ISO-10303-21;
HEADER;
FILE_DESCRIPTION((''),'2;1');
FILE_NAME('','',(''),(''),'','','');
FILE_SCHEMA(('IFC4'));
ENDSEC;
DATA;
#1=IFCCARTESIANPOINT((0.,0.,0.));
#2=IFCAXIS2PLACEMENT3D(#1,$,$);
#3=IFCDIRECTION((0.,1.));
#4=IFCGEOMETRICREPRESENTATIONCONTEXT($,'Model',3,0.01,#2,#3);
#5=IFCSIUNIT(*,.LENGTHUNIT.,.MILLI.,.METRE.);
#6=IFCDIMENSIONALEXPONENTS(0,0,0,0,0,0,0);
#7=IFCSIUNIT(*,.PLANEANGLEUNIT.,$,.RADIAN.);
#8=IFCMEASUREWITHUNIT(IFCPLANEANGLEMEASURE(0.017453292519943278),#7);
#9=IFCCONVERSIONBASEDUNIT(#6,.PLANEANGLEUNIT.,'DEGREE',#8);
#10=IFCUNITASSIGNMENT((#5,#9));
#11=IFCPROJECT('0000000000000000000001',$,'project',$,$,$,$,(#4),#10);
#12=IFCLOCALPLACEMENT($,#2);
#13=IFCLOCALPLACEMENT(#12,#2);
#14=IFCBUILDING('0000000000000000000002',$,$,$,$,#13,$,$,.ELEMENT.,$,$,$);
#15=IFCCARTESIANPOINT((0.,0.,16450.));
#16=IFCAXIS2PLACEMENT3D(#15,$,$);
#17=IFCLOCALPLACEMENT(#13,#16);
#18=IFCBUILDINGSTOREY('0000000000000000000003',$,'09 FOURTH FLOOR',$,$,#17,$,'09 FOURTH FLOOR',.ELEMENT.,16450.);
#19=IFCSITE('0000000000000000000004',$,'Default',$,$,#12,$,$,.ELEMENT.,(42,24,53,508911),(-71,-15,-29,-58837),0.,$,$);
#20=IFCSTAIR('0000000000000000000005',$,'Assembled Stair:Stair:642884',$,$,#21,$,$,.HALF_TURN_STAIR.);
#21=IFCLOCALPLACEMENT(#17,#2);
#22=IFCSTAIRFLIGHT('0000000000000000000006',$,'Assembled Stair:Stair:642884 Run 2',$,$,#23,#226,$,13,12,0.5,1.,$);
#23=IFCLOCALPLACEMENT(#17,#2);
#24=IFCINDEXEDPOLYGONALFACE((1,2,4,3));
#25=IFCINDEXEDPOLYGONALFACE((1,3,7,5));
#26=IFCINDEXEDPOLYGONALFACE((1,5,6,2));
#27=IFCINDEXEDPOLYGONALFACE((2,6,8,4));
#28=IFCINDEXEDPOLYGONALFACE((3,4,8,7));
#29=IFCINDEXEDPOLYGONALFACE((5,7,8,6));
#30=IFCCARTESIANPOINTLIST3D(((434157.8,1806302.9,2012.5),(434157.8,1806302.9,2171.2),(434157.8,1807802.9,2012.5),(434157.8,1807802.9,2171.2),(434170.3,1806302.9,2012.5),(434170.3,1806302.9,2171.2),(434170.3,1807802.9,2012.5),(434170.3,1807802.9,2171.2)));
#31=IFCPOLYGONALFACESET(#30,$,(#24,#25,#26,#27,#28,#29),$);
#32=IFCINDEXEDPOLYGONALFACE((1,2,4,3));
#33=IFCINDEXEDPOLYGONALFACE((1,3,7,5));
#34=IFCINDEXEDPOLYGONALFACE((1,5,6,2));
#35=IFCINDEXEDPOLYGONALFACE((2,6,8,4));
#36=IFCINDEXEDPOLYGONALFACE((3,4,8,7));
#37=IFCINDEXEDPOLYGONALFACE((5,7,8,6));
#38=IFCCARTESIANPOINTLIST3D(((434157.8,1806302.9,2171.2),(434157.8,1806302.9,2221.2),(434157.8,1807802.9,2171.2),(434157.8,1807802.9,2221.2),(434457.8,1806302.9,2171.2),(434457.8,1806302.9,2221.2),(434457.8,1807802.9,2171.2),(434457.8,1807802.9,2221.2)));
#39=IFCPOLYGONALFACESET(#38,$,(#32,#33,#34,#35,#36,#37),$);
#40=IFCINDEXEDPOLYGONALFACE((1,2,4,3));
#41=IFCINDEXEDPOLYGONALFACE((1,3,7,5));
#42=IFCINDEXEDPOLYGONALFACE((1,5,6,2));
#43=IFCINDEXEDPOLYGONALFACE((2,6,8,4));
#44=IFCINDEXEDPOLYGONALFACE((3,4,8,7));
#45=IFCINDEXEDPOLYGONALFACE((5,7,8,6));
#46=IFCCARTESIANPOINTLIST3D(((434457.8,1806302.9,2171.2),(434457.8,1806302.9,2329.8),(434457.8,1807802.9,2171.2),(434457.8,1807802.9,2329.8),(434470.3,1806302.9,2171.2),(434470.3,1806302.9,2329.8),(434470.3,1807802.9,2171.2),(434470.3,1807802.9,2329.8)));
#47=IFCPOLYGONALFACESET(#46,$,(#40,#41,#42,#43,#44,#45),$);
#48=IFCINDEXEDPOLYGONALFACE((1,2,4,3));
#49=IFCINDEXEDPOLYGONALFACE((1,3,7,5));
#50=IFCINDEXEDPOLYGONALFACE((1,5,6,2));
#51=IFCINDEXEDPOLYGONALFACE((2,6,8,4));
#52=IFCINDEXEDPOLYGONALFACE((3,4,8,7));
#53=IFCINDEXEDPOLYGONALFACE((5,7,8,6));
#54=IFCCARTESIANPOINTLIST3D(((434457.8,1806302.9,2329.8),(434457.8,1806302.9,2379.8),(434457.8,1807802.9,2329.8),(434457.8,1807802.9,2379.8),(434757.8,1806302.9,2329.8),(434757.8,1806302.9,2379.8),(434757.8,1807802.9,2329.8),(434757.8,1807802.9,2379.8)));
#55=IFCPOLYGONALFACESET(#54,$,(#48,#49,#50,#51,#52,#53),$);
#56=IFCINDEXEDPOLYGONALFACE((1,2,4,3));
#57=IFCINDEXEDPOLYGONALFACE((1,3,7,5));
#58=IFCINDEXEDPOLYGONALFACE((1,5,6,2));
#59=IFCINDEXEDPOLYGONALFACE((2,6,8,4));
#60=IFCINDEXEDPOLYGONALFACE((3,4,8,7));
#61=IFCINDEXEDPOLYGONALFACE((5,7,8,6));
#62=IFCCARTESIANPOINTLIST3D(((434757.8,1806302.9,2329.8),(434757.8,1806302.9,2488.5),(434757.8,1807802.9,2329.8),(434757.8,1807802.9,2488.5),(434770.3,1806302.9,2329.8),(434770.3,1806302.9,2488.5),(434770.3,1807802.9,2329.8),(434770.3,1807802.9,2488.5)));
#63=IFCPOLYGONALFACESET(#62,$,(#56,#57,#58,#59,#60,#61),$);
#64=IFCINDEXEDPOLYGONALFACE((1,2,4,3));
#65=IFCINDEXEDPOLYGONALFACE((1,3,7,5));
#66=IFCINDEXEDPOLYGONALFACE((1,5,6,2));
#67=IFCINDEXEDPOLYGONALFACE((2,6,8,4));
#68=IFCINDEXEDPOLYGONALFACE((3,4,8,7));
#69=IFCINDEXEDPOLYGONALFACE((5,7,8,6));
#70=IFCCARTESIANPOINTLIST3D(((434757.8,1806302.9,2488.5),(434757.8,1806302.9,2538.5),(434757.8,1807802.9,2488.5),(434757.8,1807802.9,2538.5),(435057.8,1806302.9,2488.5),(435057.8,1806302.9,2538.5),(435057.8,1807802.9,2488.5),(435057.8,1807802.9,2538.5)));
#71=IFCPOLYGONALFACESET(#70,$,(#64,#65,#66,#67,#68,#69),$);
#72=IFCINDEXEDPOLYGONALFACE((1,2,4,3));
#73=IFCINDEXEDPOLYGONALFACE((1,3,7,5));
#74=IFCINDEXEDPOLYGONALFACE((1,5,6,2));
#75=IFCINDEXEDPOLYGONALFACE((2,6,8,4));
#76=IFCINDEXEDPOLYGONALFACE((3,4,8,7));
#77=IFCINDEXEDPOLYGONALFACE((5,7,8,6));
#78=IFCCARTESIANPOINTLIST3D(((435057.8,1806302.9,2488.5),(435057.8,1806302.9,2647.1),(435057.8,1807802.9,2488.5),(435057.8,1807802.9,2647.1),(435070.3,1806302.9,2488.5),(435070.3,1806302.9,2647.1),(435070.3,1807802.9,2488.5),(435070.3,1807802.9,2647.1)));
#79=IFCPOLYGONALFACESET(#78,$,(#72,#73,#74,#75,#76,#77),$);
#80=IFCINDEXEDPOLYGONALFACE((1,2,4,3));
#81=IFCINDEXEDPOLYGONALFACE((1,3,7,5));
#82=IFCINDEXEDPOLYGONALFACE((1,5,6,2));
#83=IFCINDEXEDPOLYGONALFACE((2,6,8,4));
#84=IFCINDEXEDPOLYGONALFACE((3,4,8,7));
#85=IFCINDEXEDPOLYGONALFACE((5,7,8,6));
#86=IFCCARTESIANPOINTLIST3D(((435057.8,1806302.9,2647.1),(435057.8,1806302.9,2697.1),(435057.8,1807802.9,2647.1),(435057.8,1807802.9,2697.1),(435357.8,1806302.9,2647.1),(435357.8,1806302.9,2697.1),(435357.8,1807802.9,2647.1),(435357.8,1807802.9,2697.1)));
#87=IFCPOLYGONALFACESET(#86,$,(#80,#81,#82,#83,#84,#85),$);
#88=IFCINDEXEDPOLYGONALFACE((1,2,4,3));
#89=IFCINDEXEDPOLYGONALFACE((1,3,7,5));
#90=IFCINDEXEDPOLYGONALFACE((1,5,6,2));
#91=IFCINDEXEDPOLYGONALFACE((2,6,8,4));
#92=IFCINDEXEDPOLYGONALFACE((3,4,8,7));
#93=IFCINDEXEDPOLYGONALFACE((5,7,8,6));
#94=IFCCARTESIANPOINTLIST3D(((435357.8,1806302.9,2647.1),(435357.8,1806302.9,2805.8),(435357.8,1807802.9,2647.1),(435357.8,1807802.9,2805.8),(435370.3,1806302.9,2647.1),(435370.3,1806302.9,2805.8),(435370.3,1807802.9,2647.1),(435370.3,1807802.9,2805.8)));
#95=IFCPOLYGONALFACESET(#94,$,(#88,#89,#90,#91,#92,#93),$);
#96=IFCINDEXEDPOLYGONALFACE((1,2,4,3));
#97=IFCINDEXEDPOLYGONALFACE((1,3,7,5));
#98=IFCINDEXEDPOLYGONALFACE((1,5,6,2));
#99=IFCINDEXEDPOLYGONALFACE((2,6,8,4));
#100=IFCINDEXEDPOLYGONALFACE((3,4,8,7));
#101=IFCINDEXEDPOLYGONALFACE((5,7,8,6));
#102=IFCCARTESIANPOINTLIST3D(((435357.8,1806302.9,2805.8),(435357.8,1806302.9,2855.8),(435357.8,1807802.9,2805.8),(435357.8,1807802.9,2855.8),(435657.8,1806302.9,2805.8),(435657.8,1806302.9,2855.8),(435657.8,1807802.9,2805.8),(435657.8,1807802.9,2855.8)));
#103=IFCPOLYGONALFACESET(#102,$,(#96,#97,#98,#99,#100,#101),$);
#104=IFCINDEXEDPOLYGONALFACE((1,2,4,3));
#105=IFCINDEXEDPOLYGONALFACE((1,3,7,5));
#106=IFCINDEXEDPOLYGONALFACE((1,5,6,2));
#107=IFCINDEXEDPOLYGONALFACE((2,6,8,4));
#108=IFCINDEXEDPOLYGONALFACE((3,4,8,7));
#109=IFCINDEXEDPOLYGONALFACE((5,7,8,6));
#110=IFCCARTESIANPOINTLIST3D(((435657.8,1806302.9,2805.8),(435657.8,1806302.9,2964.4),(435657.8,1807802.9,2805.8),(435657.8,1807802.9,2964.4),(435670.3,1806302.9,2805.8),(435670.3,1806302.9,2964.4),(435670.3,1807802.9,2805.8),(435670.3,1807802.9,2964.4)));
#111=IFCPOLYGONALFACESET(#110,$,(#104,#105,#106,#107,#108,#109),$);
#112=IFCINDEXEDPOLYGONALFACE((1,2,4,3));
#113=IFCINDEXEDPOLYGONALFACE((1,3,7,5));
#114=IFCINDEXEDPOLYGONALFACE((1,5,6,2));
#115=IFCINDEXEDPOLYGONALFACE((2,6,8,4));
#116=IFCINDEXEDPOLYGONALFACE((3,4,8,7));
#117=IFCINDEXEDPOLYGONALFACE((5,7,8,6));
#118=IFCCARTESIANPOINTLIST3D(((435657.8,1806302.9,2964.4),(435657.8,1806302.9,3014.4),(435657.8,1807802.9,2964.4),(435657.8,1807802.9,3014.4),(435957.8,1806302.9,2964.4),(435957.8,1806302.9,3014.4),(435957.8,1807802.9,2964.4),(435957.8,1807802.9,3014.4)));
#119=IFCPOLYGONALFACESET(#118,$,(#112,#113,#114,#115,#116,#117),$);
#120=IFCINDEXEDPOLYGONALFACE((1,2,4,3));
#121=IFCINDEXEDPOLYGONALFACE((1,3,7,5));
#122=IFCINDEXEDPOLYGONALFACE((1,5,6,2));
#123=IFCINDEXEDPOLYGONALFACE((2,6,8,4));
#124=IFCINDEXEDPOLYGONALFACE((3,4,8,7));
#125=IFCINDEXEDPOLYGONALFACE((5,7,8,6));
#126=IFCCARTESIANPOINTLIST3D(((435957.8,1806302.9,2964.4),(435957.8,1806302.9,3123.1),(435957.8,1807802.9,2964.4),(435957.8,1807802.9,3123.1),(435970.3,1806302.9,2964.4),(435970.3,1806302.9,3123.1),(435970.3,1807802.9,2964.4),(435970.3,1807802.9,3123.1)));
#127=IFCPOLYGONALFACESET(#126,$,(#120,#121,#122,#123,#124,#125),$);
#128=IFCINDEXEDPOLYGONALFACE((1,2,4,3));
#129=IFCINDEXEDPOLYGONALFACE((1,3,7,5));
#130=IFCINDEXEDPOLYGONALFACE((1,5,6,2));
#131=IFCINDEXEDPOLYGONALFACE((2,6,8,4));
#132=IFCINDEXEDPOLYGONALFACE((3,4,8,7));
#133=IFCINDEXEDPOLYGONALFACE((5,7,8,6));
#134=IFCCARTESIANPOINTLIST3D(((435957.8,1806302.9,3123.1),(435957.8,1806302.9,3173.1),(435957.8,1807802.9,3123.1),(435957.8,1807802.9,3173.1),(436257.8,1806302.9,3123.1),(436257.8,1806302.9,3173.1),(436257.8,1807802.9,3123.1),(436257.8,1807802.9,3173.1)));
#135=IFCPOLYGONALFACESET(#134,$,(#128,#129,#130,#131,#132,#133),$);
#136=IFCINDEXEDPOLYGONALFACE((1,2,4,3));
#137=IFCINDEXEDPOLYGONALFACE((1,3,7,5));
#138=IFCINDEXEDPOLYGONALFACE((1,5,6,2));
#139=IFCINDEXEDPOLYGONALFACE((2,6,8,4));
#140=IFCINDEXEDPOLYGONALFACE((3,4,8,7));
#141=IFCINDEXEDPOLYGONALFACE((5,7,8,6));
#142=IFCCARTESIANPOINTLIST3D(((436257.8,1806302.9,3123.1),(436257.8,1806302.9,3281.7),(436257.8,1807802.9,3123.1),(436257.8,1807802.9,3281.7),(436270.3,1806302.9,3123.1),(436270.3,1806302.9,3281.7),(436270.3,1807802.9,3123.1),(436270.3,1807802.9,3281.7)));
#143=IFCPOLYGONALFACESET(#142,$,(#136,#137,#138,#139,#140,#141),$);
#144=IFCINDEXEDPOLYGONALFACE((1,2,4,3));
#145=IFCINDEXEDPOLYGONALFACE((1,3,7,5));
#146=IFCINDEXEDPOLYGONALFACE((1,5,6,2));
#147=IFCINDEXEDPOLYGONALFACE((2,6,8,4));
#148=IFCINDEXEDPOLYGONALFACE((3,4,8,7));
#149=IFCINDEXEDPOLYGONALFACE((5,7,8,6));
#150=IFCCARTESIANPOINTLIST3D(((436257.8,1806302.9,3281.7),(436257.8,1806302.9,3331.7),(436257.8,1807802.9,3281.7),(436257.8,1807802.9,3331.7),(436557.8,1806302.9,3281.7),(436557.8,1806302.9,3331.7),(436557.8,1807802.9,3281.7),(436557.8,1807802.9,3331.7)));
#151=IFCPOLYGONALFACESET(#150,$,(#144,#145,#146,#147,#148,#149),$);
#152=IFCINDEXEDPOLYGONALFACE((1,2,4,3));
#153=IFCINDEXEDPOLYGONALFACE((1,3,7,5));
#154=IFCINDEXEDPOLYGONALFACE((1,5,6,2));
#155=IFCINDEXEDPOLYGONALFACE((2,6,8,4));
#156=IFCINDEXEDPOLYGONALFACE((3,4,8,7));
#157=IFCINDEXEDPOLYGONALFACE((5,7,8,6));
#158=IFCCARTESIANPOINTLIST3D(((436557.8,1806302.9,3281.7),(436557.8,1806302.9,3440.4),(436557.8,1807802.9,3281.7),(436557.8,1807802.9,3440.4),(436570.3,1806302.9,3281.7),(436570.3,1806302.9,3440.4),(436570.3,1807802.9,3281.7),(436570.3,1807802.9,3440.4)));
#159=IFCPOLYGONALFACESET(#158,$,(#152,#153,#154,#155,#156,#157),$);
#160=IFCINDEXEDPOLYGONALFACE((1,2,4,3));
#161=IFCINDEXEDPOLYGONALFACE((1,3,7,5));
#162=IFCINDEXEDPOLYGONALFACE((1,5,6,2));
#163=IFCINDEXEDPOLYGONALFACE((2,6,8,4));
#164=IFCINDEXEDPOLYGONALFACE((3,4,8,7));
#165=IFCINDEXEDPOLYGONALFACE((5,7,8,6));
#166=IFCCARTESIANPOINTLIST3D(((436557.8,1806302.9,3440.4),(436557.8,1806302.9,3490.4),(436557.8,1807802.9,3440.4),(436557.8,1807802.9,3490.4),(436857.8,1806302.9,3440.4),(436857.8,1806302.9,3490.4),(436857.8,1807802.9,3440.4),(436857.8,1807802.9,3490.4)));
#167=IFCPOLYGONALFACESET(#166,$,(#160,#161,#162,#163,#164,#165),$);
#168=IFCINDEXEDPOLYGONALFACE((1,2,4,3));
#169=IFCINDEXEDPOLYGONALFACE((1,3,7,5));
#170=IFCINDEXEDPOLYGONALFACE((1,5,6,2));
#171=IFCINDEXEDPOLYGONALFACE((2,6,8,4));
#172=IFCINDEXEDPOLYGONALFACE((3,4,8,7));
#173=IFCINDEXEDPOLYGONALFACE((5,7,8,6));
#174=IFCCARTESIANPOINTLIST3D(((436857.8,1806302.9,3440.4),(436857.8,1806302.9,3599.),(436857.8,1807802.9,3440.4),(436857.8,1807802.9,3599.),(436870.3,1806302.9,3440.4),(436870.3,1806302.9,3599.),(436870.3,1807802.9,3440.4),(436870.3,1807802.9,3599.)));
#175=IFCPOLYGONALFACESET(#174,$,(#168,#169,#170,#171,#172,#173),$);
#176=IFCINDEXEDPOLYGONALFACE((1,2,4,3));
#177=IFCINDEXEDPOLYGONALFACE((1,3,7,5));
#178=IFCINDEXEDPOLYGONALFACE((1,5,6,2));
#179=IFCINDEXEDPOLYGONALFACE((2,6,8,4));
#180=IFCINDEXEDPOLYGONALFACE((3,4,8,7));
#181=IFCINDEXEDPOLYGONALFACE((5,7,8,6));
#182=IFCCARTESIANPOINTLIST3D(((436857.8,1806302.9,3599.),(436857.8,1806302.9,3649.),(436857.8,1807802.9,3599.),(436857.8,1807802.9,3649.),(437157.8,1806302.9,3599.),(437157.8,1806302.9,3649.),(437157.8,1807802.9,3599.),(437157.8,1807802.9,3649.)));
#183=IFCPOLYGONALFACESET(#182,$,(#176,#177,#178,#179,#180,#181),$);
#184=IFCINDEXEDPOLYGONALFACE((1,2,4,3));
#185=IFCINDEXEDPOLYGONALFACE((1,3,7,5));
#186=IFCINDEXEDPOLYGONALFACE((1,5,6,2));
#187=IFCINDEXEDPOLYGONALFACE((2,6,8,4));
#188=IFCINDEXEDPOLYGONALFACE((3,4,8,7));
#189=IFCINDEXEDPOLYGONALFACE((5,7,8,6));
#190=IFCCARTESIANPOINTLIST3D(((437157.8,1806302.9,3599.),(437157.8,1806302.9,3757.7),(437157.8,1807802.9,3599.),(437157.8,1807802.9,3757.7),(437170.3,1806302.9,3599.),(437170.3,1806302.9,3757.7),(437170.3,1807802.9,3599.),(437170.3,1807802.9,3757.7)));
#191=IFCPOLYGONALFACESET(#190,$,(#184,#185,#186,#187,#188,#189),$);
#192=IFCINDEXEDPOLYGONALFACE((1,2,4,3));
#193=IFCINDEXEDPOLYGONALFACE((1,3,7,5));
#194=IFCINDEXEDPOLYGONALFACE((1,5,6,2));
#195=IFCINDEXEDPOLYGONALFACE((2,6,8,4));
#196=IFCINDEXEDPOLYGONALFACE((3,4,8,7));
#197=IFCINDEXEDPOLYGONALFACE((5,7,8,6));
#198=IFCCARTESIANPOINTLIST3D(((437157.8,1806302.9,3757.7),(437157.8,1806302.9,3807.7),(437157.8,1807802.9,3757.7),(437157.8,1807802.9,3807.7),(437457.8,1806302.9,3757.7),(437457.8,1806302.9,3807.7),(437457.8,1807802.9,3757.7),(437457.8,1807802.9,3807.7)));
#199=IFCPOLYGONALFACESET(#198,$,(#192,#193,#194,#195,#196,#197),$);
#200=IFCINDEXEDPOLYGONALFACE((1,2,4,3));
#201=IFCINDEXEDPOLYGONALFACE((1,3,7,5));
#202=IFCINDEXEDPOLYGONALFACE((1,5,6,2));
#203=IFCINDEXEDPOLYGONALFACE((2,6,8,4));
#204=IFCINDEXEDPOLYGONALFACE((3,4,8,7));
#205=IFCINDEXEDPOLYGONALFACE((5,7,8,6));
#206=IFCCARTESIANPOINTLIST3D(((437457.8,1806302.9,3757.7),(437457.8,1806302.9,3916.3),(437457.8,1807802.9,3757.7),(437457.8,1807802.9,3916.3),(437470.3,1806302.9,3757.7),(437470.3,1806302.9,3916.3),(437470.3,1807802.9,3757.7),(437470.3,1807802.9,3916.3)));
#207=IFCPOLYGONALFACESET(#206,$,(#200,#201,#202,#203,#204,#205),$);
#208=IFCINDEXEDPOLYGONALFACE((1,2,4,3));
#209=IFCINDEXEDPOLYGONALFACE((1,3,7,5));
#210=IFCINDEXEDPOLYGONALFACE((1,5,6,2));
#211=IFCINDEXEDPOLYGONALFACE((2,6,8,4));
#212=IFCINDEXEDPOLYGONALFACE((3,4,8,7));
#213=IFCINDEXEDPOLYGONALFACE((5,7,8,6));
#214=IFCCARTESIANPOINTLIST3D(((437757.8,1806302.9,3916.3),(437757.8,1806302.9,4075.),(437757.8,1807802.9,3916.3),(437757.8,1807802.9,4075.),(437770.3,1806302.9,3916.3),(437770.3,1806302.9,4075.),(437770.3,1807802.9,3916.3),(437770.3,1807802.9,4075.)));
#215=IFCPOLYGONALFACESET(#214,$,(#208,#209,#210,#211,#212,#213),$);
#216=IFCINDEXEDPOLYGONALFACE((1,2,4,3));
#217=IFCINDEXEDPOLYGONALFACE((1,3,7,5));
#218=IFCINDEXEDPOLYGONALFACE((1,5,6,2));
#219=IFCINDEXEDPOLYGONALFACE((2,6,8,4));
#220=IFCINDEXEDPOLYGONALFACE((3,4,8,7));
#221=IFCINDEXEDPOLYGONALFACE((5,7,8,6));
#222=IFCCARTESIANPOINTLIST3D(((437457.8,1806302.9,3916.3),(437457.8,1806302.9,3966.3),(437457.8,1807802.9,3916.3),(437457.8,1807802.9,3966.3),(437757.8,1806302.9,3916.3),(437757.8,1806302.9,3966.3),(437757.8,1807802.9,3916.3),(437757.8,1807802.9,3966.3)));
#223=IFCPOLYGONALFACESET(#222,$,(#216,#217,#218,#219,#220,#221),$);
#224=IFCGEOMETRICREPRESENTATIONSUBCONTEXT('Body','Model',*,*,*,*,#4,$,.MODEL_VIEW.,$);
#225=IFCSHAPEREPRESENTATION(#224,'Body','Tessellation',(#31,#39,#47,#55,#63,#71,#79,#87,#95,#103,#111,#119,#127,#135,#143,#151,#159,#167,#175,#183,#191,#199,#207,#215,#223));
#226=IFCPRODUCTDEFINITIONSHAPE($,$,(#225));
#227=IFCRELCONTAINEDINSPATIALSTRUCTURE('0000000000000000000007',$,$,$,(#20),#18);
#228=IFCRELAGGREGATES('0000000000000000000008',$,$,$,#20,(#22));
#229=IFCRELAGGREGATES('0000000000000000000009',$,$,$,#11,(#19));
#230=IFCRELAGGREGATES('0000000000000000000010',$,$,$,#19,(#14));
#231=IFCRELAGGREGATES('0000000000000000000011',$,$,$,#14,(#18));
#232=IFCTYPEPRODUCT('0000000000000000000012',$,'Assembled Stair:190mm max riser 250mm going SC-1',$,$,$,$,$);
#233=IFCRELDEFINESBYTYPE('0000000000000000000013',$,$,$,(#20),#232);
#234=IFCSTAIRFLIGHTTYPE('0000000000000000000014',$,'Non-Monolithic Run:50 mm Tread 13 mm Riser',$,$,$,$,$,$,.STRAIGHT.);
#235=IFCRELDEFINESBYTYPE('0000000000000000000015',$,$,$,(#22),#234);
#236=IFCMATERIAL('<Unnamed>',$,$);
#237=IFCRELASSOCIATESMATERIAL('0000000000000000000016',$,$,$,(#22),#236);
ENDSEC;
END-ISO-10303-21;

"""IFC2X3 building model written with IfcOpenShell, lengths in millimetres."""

from ifc_helpers import new_model, entity, si_unit, converted_unit, direction, frame, origin, origin_2d_with_axis, place, context, subcontext, project, spatial, rectangle, extrude, material, type_object, element, aggregate, save


model = new_model("IFC2X3")

# Units and contexts
model_context = context("Model", 3, precision=0.01, world=origin(), true_north=direction((0.0, 1.0)))
body_context = subcontext(model_context, "Body", "Model", "MODEL_VIEW")
ifc_project = project(units=[si_unit("LENGTHUNIT", "METRE", prefix="MILLI"), converted_unit("PLANEANGLEUNIT", "DEGREE", entity("IfcPlaneAngleMeasure", 0.017453292519943278), si_unit("PLANEANGLEUNIT", "RADIAN"), dimensions=[0, 0, 0, 0, 0, 0, 0])], contexts=[model_context])

# Site, building, storey
site_placement = place(None, origin())
site = spatial("IfcSite", under=ifc_project, at=site_placement, Name="Default", CompositionType="ELEMENT", RefLatitude=(42, 24, 53, 508911), RefLongitude=(-71, -15, -29, -58837), RefElevation=0.0)
building_placement = place(site_placement, origin())
building = spatial("IfcBuilding", under=site, at=building_placement, CompositionType="ELEMENT")
storey_placement = place(building_placement, frame((0.0, 0.0, 16450.0)))
storey = spatial("IfcBuildingStorey", under=building, at=storey_placement, Name="09 FOURTH FLOOR", LongName="09 FOURTH FLOOR", CompositionType="ELEMENT", Elevation=16450.0)

# Stair
type_product_1 = type_object("IfcTypeProduct", Name="Assembled Stair:190mm max riser 250mm going SC-1")
stair_1_placement = place(storey_placement, origin())
stair_1 = element("IfcStair", 1, at=stair_1_placement, inside=storey, type_object=type_product_1, Name="Assembled Stair:Stair:642884", ShapeType="HALF_TURN_STAIR")
ifc_material_1 = material(Name="<Unnamed>")

# Stair flight
stair_flight_type = type_object("IfcStairFlightType", Name="Non-Monolithic Run:50 mm Tread 13 mm Riser", PredefinedType="STRAIGHT")
stair_flight_1_placement = place(stair_1_placement, origin())
stair_flight_1 = element("IfcStairFlight", 2, at=stair_flight_1_placement, type_object=stair_flight_type, material=ifc_material_1, Name="Assembled Stair:Stair:642884 Run 2", NumberOfRiser=13, NumberOfTreads=12, RiserHeight=0.5, TreadLength=1.0, context=body_context, shape_type="SweptSolid", body=[
    extrude(rectangle(XDim=1500.0, YDim=12.5, at=origin_2d_with_axis()), frame((434164.0, 1807052.9, 2012.5), z_axis=(0.0, 0.0, 1.0), x_axis=(0.0, 1.0, 0.0)), (0.0, 0.0, 1.0), 158.7),
    extrude(rectangle(XDim=300.0, YDim=1500.0, at=origin_2d_with_axis()), frame((434307.8, 1807052.9, 2171.2), z_axis=(0.0, 0.0, 1.0), x_axis=(-1.0, 0.0, 0.0)), (0.0, 0.0, 1.0), 50.0),
    extrude(rectangle(XDim=1500.0, YDim=12.5, at=origin_2d_with_axis()), frame((434464.0, 1807052.9, 2171.2), z_axis=(0.0, 0.0, 1.0), x_axis=(0.0, 1.0, 0.0)), (0.0, 0.0, 1.0), 158.7),
    extrude(rectangle(XDim=300.0, YDim=1500.0, at=origin_2d_with_axis()), frame((434607.8, 1807052.9, 2329.8), z_axis=(0.0, 0.0, 1.0), x_axis=(-1.0, 0.0, 0.0)), (0.0, 0.0, 1.0), 50.0),
    extrude(rectangle(XDim=1500.0, YDim=12.5, at=origin_2d_with_axis()), frame((434764.0, 1807052.9, 2329.8), z_axis=(0.0, 0.0, 1.0), x_axis=(0.0, 1.0, 0.0)), (0.0, 0.0, 1.0), 158.7),
    extrude(rectangle(XDim=300.0, YDim=1500.0, at=origin_2d_with_axis()), frame((434907.8, 1807052.9, 2488.5), z_axis=(0.0, 0.0, 1.0), x_axis=(-1.0, 0.0, 0.0)), (0.0, 0.0, 1.0), 50.0),
    extrude(rectangle(XDim=1500.0, YDim=12.5, at=origin_2d_with_axis()), frame((435064.0, 1807052.9, 2488.5), z_axis=(0.0, 0.0, 1.0), x_axis=(0.0, 1.0, 0.0)), (0.0, 0.0, 1.0), 158.7),
    extrude(rectangle(XDim=300.0, YDim=1500.0, at=origin_2d_with_axis()), frame((435207.8, 1807052.9, 2647.1), z_axis=(0.0, 0.0, 1.0), x_axis=(-1.0, 0.0, 0.0)), (0.0, 0.0, 1.0), 50.0),
    extrude(rectangle(XDim=1500.0, YDim=12.5, at=origin_2d_with_axis()), frame((435364.0, 1807052.9, 2647.1), z_axis=(0.0, 0.0, 1.0), x_axis=(0.0, 1.0, 0.0)), (0.0, 0.0, 1.0), 158.7),
    extrude(rectangle(XDim=300.0, YDim=1500.0, at=origin_2d_with_axis()), frame((435507.8, 1807052.9, 2805.8), z_axis=(0.0, 0.0, 1.0), x_axis=(-1.0, 0.0, 0.0)), (0.0, 0.0, 1.0), 50.0),
    extrude(rectangle(XDim=1500.0, YDim=12.5, at=origin_2d_with_axis()), frame((435664.0, 1807052.9, 2805.8), z_axis=(0.0, 0.0, 1.0), x_axis=(0.0, 1.0, 0.0)), (0.0, 0.0, 1.0), 158.7),
    extrude(rectangle(XDim=300.0, YDim=1500.0, at=origin_2d_with_axis()), frame((435807.8, 1807052.9, 2964.4), z_axis=(0.0, 0.0, 1.0), x_axis=(-1.0, 0.0, 0.0)), (0.0, 0.0, 1.0), 50.0),
    extrude(rectangle(XDim=1500.0, YDim=12.5, at=origin_2d_with_axis()), frame((435964.0, 1807052.9, 2964.4), z_axis=(0.0, 0.0, 1.0), x_axis=(0.0, 1.0, 0.0)), (0.0, 0.0, 1.0), 158.7),
    extrude(rectangle(XDim=300.0, YDim=1500.0, at=origin_2d_with_axis()), frame((436107.8, 1807052.9, 3123.1), z_axis=(0.0, 0.0, 1.0), x_axis=(-1.0, 0.0, 0.0)), (0.0, 0.0, 1.0), 50.0),
    extrude(rectangle(XDim=1500.0, YDim=12.5, at=origin_2d_with_axis()), frame((436264.0, 1807052.9, 3123.1), z_axis=(0.0, 0.0, 1.0), x_axis=(0.0, 1.0, 0.0)), (0.0, 0.0, 1.0), 158.7),
    extrude(rectangle(XDim=300.0, YDim=1500.0, at=origin_2d_with_axis()), frame((436407.8, 1807052.9, 3281.7), z_axis=(0.0, 0.0, 1.0), x_axis=(-1.0, 0.0, 0.0)), (0.0, 0.0, 1.0), 50.0),
    extrude(rectangle(XDim=1500.0, YDim=12.5, at=origin_2d_with_axis()), frame((436564.0, 1807052.9, 3281.7), z_axis=(0.0, 0.0, 1.0), x_axis=(0.0, 1.0, 0.0)), (0.0, 0.0, 1.0), 158.7),
    extrude(rectangle(XDim=300.0, YDim=1500.0, at=origin_2d_with_axis()), frame((436707.8, 1807052.9, 3440.4), z_axis=(0.0, 0.0, 1.0), x_axis=(-1.0, 0.0, 0.0)), (0.0, 0.0, 1.0), 50.0),
    extrude(rectangle(XDim=1500.0, YDim=12.5, at=origin_2d_with_axis()), frame((436864.0, 1807052.9, 3440.4), z_axis=(0.0, 0.0, 1.0), x_axis=(0.0, 1.0, 0.0)), (0.0, 0.0, 1.0), 158.7),
    extrude(rectangle(XDim=300.0, YDim=1500.0, at=origin_2d_with_axis()), frame((437007.8, 1807052.9, 3599.0), z_axis=(0.0, 0.0, 1.0), x_axis=(-1.0, 0.0, 0.0)), (0.0, 0.0, 1.0), 50.0),
    extrude(rectangle(XDim=1500.0, YDim=12.5, at=origin_2d_with_axis()), frame((437164.0, 1807052.9, 3599.0), z_axis=(0.0, 0.0, 1.0), x_axis=(0.0, 1.0, 0.0)), (0.0, 0.0, 1.0), 158.7),
    extrude(rectangle(XDim=300.0, YDim=1500.0, at=origin_2d_with_axis()), frame((437307.8, 1807052.9, 3757.7), z_axis=(0.0, 0.0, 1.0), x_axis=(-1.0, 0.0, 0.0)), (0.0, 0.0, 1.0), 50.0),
    extrude(rectangle(XDim=1500.0, YDim=12.5, at=origin_2d_with_axis()), frame((437464.0, 1807052.9, 3757.7), z_axis=(0.0, 0.0, 1.0), x_axis=(0.0, 1.0, 0.0)), (0.0, 0.0, 1.0), 158.7),
    extrude(rectangle(XDim=1500.0, YDim=12.5, at=origin_2d_with_axis()), frame((437764.0, 1807052.9, 3916.3), z_axis=(0.0, 0.0, 1.0), x_axis=(0.0, 1.0, 0.0)), (0.0, 0.0, 1.0), 158.7),
    extrude(rectangle(XDim=300.0, YDim=1500.0, at=origin_2d_with_axis()), frame((437607.8, 1807052.9, 3916.3), z_axis=(0.0, 0.0, 1.0), x_axis=(-1.0, 0.0, 0.0)), (0.0, 0.0, 1.0), 50.0),
])
aggregate(stair_1, [stair_flight_1])

save(model, "model.ifc")
